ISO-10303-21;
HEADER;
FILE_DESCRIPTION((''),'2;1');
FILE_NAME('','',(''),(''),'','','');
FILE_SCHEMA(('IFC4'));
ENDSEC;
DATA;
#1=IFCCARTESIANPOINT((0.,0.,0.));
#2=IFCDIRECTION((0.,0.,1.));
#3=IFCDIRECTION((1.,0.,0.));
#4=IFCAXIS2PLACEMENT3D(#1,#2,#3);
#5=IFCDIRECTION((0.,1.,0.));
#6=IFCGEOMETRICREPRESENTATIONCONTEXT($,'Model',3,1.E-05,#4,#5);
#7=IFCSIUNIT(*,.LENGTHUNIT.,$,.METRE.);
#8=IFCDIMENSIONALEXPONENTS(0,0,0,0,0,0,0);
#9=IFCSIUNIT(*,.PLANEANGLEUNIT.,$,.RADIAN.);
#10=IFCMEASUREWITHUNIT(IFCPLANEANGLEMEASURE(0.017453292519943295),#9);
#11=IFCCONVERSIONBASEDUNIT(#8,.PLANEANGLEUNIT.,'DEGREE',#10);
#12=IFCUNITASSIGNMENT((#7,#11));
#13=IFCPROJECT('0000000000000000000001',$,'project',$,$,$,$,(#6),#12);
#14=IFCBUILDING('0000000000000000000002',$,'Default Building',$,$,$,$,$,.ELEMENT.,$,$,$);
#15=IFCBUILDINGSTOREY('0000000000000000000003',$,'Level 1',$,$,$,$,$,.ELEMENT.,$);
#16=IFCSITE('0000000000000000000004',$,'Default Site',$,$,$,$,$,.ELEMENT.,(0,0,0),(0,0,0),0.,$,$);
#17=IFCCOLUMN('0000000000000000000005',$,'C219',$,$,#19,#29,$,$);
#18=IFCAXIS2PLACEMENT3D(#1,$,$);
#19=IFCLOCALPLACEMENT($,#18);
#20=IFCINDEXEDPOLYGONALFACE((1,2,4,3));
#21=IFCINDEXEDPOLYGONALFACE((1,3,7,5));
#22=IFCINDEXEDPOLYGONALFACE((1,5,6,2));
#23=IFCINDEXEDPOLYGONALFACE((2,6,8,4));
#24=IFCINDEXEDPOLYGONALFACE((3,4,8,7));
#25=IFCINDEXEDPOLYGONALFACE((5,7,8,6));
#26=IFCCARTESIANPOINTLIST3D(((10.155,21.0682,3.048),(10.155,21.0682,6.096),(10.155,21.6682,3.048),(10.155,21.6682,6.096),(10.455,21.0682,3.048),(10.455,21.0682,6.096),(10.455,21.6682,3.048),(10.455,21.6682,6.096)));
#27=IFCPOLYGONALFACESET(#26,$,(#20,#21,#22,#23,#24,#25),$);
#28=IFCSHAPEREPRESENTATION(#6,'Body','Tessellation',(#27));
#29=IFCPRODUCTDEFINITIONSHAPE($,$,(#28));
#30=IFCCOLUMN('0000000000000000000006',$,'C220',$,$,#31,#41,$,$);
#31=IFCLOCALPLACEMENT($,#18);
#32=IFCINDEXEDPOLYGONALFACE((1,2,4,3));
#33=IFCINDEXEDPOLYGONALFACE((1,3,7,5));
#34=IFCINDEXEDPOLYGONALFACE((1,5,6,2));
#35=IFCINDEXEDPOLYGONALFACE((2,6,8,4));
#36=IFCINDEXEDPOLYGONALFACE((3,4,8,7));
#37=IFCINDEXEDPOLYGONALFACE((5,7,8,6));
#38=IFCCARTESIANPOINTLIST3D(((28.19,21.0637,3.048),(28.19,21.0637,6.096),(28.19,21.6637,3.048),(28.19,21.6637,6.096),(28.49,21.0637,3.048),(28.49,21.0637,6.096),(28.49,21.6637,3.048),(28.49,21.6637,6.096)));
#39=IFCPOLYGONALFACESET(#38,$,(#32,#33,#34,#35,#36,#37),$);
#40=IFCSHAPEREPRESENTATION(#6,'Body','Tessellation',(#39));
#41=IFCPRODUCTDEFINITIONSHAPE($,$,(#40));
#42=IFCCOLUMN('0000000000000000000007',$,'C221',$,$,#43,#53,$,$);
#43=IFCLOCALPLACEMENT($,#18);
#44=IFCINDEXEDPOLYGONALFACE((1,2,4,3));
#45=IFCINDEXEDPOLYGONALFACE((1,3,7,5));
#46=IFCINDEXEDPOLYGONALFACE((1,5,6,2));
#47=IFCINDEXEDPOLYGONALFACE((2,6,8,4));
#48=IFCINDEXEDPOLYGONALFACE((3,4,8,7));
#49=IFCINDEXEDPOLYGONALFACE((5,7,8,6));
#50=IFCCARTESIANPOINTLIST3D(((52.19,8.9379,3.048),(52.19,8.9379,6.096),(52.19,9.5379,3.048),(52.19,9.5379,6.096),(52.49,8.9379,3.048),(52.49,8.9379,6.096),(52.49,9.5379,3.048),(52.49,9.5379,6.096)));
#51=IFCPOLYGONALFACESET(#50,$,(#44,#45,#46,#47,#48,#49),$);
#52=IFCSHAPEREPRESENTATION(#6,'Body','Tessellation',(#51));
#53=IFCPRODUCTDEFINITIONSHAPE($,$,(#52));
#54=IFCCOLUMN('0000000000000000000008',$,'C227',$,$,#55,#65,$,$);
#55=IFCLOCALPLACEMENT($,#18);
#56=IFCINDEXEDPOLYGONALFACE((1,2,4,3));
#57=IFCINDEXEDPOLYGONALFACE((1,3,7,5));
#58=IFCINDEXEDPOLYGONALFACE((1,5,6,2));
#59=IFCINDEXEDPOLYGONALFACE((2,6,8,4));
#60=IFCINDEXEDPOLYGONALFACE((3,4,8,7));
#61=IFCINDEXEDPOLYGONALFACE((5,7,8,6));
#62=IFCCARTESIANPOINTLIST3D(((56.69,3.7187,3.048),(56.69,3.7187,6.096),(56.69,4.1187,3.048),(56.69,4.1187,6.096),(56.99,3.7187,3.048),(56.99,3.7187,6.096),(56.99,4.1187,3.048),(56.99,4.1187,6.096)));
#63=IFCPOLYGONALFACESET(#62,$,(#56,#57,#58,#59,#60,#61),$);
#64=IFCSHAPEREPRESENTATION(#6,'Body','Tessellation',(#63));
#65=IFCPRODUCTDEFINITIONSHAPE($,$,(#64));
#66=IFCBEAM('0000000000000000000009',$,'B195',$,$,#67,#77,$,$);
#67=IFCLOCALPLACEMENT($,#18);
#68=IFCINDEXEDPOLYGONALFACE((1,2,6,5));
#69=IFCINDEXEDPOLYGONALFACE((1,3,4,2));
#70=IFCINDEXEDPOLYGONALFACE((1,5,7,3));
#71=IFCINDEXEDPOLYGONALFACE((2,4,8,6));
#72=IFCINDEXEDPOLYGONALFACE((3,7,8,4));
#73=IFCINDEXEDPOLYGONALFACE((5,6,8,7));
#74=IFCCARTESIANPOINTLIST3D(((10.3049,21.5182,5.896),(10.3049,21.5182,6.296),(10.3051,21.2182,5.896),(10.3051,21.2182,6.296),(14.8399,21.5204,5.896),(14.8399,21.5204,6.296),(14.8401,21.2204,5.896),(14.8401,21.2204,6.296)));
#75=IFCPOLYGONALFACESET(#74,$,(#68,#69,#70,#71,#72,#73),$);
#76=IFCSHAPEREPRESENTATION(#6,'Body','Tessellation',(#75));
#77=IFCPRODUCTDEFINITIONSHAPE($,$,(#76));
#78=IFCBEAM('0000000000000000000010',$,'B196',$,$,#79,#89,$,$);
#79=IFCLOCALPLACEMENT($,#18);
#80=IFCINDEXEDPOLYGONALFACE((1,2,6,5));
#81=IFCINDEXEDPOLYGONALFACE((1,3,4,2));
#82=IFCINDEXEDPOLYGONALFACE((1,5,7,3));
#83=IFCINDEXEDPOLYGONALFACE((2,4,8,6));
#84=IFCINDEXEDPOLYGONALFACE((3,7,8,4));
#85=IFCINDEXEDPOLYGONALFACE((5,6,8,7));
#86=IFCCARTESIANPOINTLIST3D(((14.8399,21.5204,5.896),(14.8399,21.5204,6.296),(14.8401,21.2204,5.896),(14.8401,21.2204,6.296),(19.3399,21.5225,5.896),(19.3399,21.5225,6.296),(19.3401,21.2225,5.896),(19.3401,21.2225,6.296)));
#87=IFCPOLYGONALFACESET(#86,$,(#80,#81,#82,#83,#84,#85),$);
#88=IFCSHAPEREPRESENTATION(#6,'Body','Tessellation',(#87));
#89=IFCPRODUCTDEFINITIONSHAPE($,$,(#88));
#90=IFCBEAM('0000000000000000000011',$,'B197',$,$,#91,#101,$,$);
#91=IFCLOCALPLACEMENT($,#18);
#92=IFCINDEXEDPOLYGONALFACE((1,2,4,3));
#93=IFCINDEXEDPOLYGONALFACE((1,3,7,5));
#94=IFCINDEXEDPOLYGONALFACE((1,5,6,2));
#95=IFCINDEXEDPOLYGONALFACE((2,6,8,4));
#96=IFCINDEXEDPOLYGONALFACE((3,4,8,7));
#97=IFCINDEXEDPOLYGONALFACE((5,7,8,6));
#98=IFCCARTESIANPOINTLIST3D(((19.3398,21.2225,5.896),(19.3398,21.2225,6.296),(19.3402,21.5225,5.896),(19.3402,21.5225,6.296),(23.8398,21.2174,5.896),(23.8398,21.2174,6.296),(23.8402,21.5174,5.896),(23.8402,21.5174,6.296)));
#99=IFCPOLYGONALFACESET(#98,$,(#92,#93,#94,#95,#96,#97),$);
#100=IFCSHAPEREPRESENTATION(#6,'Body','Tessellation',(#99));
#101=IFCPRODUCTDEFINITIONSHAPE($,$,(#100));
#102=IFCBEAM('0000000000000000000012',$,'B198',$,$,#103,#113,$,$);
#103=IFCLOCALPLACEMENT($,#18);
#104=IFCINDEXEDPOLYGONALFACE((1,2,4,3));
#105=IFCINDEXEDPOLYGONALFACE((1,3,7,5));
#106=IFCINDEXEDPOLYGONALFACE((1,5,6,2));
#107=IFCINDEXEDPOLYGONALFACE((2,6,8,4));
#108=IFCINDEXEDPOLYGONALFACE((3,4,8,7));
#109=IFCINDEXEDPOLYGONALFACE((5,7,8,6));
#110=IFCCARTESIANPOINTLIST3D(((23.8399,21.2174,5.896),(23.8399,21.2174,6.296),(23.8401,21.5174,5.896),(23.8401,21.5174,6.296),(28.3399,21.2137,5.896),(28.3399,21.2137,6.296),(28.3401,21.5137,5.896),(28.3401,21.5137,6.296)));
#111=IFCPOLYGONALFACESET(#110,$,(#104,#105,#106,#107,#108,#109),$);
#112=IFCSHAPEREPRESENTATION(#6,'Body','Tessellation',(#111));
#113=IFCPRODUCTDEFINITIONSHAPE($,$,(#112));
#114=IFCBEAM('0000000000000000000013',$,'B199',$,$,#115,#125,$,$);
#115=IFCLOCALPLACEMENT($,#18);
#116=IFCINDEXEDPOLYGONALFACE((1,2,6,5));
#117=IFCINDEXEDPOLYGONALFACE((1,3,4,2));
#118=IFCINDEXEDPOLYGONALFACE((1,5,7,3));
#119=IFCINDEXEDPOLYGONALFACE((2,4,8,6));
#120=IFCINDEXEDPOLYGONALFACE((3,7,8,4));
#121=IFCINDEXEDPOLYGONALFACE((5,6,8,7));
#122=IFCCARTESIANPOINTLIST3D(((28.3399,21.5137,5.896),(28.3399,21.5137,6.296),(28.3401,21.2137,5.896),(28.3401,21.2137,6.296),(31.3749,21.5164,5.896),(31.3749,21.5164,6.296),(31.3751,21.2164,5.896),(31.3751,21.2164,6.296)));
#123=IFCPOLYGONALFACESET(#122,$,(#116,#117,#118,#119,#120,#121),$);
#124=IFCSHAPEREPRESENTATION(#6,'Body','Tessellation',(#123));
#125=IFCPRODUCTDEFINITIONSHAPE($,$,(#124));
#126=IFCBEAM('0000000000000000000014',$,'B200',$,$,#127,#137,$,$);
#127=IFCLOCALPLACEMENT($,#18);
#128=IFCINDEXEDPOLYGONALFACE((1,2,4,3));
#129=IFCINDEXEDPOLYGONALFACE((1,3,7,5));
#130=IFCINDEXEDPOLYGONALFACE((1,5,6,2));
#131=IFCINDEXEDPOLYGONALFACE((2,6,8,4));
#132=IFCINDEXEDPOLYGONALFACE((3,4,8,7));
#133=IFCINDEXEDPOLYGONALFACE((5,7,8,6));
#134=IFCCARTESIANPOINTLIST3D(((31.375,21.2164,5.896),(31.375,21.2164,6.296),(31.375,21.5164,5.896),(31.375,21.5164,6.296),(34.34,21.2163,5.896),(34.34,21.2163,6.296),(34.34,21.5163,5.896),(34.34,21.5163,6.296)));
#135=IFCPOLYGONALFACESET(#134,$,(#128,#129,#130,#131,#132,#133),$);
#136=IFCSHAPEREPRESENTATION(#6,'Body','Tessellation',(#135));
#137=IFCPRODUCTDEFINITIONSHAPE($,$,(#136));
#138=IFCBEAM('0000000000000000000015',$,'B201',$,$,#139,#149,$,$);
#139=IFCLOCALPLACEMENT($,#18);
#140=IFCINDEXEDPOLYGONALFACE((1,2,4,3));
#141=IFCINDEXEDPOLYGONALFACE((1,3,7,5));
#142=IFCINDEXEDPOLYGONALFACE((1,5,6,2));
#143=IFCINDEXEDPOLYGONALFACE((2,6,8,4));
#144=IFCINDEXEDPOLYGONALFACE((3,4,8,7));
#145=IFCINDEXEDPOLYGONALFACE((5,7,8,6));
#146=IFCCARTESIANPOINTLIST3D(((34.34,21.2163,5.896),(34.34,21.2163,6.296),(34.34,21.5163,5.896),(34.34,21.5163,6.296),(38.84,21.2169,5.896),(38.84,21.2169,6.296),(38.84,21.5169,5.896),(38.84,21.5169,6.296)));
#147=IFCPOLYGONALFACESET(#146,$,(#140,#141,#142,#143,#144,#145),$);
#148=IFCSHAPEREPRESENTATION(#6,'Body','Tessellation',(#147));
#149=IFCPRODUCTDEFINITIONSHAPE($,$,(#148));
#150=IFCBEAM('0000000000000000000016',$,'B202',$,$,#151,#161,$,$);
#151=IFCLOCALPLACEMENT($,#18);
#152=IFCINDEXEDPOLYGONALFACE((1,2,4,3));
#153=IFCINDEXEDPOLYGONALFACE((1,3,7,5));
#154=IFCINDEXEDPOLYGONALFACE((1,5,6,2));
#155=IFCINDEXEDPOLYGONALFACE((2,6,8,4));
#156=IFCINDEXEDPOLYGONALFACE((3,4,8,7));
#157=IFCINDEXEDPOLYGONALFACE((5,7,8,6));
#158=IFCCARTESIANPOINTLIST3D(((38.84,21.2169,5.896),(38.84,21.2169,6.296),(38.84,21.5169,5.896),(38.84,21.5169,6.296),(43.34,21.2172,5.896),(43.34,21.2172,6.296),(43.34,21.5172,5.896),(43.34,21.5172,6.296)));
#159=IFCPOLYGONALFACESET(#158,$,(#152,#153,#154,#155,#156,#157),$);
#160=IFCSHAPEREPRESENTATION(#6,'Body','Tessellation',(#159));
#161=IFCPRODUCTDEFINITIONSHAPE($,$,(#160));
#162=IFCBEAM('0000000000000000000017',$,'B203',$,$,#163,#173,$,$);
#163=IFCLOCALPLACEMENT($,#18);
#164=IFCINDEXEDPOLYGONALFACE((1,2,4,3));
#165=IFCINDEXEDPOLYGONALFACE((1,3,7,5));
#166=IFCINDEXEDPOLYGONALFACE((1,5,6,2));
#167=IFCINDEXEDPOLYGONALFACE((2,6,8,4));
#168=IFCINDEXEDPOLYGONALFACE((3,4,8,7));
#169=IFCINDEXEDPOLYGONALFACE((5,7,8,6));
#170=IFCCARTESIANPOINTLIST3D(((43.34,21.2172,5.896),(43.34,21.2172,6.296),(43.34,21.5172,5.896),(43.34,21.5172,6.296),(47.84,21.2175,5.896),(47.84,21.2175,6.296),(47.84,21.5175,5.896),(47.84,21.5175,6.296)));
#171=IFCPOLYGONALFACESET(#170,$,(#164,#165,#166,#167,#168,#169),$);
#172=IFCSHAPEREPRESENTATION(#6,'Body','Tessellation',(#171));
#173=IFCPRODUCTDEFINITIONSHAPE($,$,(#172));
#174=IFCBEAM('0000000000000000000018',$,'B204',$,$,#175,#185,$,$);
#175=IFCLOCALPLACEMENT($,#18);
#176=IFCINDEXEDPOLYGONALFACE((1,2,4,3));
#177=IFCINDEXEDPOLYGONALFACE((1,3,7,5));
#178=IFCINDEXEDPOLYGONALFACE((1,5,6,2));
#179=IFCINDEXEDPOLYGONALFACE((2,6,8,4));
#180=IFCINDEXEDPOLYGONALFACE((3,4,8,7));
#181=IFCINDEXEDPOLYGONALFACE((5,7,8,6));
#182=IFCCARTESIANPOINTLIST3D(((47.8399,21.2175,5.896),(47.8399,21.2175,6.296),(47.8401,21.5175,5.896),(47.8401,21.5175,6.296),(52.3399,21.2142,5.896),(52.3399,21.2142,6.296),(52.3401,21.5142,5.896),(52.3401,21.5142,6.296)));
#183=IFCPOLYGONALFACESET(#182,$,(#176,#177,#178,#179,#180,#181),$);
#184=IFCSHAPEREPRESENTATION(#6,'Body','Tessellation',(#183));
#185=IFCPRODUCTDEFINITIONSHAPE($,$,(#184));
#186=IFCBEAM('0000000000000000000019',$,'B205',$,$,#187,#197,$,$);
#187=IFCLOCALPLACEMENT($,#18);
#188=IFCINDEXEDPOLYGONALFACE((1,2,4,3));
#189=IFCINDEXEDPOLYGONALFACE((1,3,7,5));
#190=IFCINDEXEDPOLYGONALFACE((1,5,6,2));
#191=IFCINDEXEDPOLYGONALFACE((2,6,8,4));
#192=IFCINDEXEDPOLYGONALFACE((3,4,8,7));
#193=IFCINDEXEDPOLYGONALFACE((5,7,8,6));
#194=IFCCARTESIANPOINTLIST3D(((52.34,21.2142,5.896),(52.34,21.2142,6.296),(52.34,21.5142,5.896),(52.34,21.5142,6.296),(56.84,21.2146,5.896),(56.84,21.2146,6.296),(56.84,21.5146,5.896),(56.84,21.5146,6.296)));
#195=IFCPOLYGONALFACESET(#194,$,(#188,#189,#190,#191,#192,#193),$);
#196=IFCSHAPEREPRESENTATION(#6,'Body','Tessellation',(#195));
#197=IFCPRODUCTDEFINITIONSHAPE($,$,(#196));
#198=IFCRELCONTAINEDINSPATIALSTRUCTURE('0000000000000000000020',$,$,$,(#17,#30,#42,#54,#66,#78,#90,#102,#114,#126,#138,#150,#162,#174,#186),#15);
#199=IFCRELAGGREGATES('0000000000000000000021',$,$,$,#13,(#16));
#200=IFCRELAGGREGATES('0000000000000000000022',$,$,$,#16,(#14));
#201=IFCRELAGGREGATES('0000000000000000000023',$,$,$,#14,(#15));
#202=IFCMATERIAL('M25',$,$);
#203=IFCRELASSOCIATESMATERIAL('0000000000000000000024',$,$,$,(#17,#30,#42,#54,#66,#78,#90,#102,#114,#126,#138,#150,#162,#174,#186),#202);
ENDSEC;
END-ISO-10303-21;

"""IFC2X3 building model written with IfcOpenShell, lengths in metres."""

from ifc_helpers import new_model, entity, si_unit, converted_unit, direction, frame, frame_2d, origin_with_axes, place, context, project, spatial, rectangle, extrude, material, element, save


model = new_model("IFC2X3")

# Units and contexts
model_context = context("Model", 3, precision=1e-05, world=origin_with_axes(), true_north=direction((0.0, 1.0, 0.0)))
ifc_project = project(units=[si_unit("LENGTHUNIT", "METRE"), converted_unit("PLANEANGLEUNIT", "DEGREE", entity("IfcPlaneAngleMeasure", 0.017453292519943295), si_unit("PLANEANGLEUNIT", "RADIAN"), dimensions=[0, 0, 0, 0, 0, 0, 0])], contexts=[model_context])

# Site, building, storey
site = spatial("IfcSite", under=ifc_project, Name="Default Site", CompositionType="ELEMENT", RefLatitude=(0, 0, 0), RefLongitude=(0, 0, 0), RefElevation=0.0)
building = spatial("IfcBuilding", under=site, Name="Default Building", CompositionType="ELEMENT")
storey = spatial("IfcBuildingStorey", under=building, Name="Level 1", CompositionType="ELEMENT")

# Columns
ifc_material = material(Name="M25")
placement = place(None, origin_with_axes())
element("IfcColumn", 1, at=placement, inside=storey, material=ifc_material, Name="C219", context=model_context, shape_type="SweptSolid", body=[
    extrude(rectangle(XDim=0.3, YDim=0.6, at=frame_2d((0.0, 0.0), x_axis=(1.0, 0.0, 0.0))), frame((10.305, 21.3682, 3.048), z_axis=(0.0, 0.0, 1.0), x_axis=(1.0, 0.0, 0.0)), (0.0, 0.0, 1.0), 3.048),
])
element("IfcColumn", 2, at=placement, inside=storey, material=ifc_material, Name="C220", context=model_context, shape_type="SweptSolid", body=[
    extrude(rectangle(XDim=0.3, YDim=0.6, at=frame_2d((0.0, 0.0), x_axis=(1.0, 0.0, 0.0))), frame((28.34, 21.3637, 3.048), z_axis=(0.0, 0.0, 1.0), x_axis=(1.0, 0.0, 0.0)), (0.0, 0.0, 1.0), 3.048),
])
element("IfcColumn", 3, at=placement, inside=storey, material=ifc_material, Name="C221", context=model_context, shape_type="SweptSolid", body=[
    extrude(rectangle(XDim=0.3, YDim=0.6, at=frame_2d((0.0, 0.0), x_axis=(1.0, 0.0, 0.0))), frame((52.34, 9.2379, 3.048), z_axis=(0.0, 0.0, 1.0), x_axis=(1.0, 0.0, 0.0)), (0.0, 0.0, 1.0), 3.048),
])
element("IfcColumn", 4, at=placement, inside=storey, material=ifc_material, Name="C227", context=model_context, shape_type="SweptSolid", body=[
    extrude(rectangle(XDim=0.3, YDim=0.4, at=frame_2d((0.0, 0.0), x_axis=(1.0, 0.0, 0.0))), frame((56.84, 3.9187, 3.048), z_axis=(0.0, 0.0, 1.0), x_axis=(1.0, 0.0, 0.0)), (0.0, 0.0, 1.0), 3.048),
])

# Beams
element("IfcBeam", 5, at=placement, inside=storey, material=ifc_material, Name="B195", context=model_context, shape_type="SweptSolid", body=[
    extrude(rectangle(XDim=0.3, YDim=0.4, at=frame_2d((0.0, 0.0), x_axis=(0.0, 1.0, 0.0))), frame((10.305, 21.3682, 6.096), z_axis=(1.0, 0.000476, 0.0), x_axis=(0.0, 0.0, -1.0)), (0.0, 0.0, 1.0), 4.535),
])
element("IfcBeam", 6, at=placement, inside=storey, material=ifc_material, Name="B196", context=model_context, shape_type="SweptSolid", body=[
    extrude(rectangle(XDim=0.3, YDim=0.4, at=frame_2d((0.0, 0.0), x_axis=(0.0, 1.0, 0.0))), frame((14.84, 21.3704, 6.096), z_axis=(1.0, 0.000471, 0.0), x_axis=(0.0, 0.0, -1.0)), (0.0, 0.0, 1.0), 4.5),
])
element("IfcBeam", 7, at=placement, inside=storey, material=ifc_material, Name="B197", context=model_context, shape_type="SweptSolid", body=[
    extrude(rectangle(XDim=0.3, YDim=0.4, at=frame_2d((0.0, 0.0), x_axis=(0.0, 1.0, 0.0))), frame((19.34, 21.3725, 6.096), z_axis=(0.999999, -0.001141, 0.0), x_axis=(0.0, 0.0, -1.0)), (0.0, 0.0, 1.0), 4.5),
])
element("IfcBeam", 8, at=placement, inside=storey, material=ifc_material, Name="B198", context=model_context, shape_type="SweptSolid", body=[
    extrude(rectangle(XDim=0.3, YDim=0.4, at=frame_2d((0.0, 0.0), x_axis=(0.0, 1.0, 0.0))), frame((23.84, 21.3674, 6.096), z_axis=(1.0, -0.000812, 0.0), x_axis=(0.0, 0.0, -1.0)), (0.0, 0.0, 1.0), 4.5),
])
element("IfcBeam", 9, at=placement, inside=storey, material=ifc_material, Name="B199", context=model_context, shape_type="SweptSolid", body=[
    extrude(rectangle(XDim=0.3, YDim=0.4, at=frame_2d((0.0, 0.0), x_axis=(0.0, 1.0, 0.0))), frame((28.34, 21.3637, 6.096), z_axis=(1.0, 0.000883, 0.0), x_axis=(0.0, 0.0, -1.0)), (0.0, 0.0, 1.0), 3.035),
])
element("IfcBeam", 10, at=placement, inside=storey, material=ifc_material, Name="B200", context=model_context, shape_type="SweptSolid", body=[
    extrude(rectangle(XDim=0.3, YDim=0.4, at=frame_2d((0.0, 0.0), x_axis=(0.0, 1.0, 0.0))), frame((31.375, 21.3664, 6.096), z_axis=(1.0, -0.000016, 0.0), x_axis=(0.0, 0.0, -1.0)), (0.0, 0.0, 1.0), 2.965),
])
element("IfcBeam", 11, at=placement, inside=storey, material=ifc_material, Name="B201", context=model_context, shape_type="SweptSolid", body=[
    extrude(rectangle(XDim=0.3, YDim=0.4, at=frame_2d((0.0, 0.0), x_axis=(0.0, 1.0, 0.0))), frame((34.34, 21.3663, 6.096), z_axis=(1.0, 0.000136, 0.0), x_axis=(0.0, 0.0, -1.0)), (0.0, 0.0, 1.0), 4.5),
])
element("IfcBeam", 12, at=placement, inside=storey, material=ifc_material, Name="B202", context=model_context, shape_type="SweptSolid", body=[
    extrude(rectangle(XDim=0.3, YDim=0.4, at=frame_2d((0.0, 0.0), x_axis=(0.0, 1.0, 0.0))), frame((38.84, 21.3669, 6.096), z_axis=(1.0, 0.00005, 0.0), x_axis=(0.0, 0.0, -1.0)), (0.0, 0.0, 1.0), 4.5),
])
element("IfcBeam", 13, at=placement, inside=storey, material=ifc_material, Name="B203", context=model_context, shape_type="SweptSolid", body=[
    extrude(rectangle(XDim=0.3, YDim=0.4, at=frame_2d((0.0, 0.0), x_axis=(0.0, 1.0, 0.0))), frame((43.34, 21.3672, 6.096), z_axis=(1.0, 0.000075, 0.0), x_axis=(0.0, 0.0, -1.0)), (0.0, 0.0, 1.0), 4.5),
])
element("IfcBeam", 14, at=placement, inside=storey, material=ifc_material, Name="B204", context=model_context, shape_type="SweptSolid", body=[
    extrude(rectangle(XDim=0.3, YDim=0.4, at=frame_2d((0.0, 0.0), x_axis=(0.0, 1.0, 0.0))), frame((47.84, 21.3675, 6.096), z_axis=(1.0, -0.000744, 0.0), x_axis=(0.0, 0.0, -1.0)), (0.0, 0.0, 1.0), 4.5),
])
element("IfcBeam", 15, at=placement, inside=storey, material=ifc_material, Name="B205", context=model_context, shape_type="SweptSolid", body=[
    extrude(rectangle(XDim=0.3, YDim=0.4, at=frame_2d((0.0, 0.0), x_axis=(0.0, 1.0, 0.0))), frame((52.34, 21.3642, 6.096), z_axis=(1.0, 0.000102, 0.0), x_axis=(0.0, 0.0, -1.0)), (0.0, 0.0, 1.0), 4.5),
])

save(model, "model.ifc")
